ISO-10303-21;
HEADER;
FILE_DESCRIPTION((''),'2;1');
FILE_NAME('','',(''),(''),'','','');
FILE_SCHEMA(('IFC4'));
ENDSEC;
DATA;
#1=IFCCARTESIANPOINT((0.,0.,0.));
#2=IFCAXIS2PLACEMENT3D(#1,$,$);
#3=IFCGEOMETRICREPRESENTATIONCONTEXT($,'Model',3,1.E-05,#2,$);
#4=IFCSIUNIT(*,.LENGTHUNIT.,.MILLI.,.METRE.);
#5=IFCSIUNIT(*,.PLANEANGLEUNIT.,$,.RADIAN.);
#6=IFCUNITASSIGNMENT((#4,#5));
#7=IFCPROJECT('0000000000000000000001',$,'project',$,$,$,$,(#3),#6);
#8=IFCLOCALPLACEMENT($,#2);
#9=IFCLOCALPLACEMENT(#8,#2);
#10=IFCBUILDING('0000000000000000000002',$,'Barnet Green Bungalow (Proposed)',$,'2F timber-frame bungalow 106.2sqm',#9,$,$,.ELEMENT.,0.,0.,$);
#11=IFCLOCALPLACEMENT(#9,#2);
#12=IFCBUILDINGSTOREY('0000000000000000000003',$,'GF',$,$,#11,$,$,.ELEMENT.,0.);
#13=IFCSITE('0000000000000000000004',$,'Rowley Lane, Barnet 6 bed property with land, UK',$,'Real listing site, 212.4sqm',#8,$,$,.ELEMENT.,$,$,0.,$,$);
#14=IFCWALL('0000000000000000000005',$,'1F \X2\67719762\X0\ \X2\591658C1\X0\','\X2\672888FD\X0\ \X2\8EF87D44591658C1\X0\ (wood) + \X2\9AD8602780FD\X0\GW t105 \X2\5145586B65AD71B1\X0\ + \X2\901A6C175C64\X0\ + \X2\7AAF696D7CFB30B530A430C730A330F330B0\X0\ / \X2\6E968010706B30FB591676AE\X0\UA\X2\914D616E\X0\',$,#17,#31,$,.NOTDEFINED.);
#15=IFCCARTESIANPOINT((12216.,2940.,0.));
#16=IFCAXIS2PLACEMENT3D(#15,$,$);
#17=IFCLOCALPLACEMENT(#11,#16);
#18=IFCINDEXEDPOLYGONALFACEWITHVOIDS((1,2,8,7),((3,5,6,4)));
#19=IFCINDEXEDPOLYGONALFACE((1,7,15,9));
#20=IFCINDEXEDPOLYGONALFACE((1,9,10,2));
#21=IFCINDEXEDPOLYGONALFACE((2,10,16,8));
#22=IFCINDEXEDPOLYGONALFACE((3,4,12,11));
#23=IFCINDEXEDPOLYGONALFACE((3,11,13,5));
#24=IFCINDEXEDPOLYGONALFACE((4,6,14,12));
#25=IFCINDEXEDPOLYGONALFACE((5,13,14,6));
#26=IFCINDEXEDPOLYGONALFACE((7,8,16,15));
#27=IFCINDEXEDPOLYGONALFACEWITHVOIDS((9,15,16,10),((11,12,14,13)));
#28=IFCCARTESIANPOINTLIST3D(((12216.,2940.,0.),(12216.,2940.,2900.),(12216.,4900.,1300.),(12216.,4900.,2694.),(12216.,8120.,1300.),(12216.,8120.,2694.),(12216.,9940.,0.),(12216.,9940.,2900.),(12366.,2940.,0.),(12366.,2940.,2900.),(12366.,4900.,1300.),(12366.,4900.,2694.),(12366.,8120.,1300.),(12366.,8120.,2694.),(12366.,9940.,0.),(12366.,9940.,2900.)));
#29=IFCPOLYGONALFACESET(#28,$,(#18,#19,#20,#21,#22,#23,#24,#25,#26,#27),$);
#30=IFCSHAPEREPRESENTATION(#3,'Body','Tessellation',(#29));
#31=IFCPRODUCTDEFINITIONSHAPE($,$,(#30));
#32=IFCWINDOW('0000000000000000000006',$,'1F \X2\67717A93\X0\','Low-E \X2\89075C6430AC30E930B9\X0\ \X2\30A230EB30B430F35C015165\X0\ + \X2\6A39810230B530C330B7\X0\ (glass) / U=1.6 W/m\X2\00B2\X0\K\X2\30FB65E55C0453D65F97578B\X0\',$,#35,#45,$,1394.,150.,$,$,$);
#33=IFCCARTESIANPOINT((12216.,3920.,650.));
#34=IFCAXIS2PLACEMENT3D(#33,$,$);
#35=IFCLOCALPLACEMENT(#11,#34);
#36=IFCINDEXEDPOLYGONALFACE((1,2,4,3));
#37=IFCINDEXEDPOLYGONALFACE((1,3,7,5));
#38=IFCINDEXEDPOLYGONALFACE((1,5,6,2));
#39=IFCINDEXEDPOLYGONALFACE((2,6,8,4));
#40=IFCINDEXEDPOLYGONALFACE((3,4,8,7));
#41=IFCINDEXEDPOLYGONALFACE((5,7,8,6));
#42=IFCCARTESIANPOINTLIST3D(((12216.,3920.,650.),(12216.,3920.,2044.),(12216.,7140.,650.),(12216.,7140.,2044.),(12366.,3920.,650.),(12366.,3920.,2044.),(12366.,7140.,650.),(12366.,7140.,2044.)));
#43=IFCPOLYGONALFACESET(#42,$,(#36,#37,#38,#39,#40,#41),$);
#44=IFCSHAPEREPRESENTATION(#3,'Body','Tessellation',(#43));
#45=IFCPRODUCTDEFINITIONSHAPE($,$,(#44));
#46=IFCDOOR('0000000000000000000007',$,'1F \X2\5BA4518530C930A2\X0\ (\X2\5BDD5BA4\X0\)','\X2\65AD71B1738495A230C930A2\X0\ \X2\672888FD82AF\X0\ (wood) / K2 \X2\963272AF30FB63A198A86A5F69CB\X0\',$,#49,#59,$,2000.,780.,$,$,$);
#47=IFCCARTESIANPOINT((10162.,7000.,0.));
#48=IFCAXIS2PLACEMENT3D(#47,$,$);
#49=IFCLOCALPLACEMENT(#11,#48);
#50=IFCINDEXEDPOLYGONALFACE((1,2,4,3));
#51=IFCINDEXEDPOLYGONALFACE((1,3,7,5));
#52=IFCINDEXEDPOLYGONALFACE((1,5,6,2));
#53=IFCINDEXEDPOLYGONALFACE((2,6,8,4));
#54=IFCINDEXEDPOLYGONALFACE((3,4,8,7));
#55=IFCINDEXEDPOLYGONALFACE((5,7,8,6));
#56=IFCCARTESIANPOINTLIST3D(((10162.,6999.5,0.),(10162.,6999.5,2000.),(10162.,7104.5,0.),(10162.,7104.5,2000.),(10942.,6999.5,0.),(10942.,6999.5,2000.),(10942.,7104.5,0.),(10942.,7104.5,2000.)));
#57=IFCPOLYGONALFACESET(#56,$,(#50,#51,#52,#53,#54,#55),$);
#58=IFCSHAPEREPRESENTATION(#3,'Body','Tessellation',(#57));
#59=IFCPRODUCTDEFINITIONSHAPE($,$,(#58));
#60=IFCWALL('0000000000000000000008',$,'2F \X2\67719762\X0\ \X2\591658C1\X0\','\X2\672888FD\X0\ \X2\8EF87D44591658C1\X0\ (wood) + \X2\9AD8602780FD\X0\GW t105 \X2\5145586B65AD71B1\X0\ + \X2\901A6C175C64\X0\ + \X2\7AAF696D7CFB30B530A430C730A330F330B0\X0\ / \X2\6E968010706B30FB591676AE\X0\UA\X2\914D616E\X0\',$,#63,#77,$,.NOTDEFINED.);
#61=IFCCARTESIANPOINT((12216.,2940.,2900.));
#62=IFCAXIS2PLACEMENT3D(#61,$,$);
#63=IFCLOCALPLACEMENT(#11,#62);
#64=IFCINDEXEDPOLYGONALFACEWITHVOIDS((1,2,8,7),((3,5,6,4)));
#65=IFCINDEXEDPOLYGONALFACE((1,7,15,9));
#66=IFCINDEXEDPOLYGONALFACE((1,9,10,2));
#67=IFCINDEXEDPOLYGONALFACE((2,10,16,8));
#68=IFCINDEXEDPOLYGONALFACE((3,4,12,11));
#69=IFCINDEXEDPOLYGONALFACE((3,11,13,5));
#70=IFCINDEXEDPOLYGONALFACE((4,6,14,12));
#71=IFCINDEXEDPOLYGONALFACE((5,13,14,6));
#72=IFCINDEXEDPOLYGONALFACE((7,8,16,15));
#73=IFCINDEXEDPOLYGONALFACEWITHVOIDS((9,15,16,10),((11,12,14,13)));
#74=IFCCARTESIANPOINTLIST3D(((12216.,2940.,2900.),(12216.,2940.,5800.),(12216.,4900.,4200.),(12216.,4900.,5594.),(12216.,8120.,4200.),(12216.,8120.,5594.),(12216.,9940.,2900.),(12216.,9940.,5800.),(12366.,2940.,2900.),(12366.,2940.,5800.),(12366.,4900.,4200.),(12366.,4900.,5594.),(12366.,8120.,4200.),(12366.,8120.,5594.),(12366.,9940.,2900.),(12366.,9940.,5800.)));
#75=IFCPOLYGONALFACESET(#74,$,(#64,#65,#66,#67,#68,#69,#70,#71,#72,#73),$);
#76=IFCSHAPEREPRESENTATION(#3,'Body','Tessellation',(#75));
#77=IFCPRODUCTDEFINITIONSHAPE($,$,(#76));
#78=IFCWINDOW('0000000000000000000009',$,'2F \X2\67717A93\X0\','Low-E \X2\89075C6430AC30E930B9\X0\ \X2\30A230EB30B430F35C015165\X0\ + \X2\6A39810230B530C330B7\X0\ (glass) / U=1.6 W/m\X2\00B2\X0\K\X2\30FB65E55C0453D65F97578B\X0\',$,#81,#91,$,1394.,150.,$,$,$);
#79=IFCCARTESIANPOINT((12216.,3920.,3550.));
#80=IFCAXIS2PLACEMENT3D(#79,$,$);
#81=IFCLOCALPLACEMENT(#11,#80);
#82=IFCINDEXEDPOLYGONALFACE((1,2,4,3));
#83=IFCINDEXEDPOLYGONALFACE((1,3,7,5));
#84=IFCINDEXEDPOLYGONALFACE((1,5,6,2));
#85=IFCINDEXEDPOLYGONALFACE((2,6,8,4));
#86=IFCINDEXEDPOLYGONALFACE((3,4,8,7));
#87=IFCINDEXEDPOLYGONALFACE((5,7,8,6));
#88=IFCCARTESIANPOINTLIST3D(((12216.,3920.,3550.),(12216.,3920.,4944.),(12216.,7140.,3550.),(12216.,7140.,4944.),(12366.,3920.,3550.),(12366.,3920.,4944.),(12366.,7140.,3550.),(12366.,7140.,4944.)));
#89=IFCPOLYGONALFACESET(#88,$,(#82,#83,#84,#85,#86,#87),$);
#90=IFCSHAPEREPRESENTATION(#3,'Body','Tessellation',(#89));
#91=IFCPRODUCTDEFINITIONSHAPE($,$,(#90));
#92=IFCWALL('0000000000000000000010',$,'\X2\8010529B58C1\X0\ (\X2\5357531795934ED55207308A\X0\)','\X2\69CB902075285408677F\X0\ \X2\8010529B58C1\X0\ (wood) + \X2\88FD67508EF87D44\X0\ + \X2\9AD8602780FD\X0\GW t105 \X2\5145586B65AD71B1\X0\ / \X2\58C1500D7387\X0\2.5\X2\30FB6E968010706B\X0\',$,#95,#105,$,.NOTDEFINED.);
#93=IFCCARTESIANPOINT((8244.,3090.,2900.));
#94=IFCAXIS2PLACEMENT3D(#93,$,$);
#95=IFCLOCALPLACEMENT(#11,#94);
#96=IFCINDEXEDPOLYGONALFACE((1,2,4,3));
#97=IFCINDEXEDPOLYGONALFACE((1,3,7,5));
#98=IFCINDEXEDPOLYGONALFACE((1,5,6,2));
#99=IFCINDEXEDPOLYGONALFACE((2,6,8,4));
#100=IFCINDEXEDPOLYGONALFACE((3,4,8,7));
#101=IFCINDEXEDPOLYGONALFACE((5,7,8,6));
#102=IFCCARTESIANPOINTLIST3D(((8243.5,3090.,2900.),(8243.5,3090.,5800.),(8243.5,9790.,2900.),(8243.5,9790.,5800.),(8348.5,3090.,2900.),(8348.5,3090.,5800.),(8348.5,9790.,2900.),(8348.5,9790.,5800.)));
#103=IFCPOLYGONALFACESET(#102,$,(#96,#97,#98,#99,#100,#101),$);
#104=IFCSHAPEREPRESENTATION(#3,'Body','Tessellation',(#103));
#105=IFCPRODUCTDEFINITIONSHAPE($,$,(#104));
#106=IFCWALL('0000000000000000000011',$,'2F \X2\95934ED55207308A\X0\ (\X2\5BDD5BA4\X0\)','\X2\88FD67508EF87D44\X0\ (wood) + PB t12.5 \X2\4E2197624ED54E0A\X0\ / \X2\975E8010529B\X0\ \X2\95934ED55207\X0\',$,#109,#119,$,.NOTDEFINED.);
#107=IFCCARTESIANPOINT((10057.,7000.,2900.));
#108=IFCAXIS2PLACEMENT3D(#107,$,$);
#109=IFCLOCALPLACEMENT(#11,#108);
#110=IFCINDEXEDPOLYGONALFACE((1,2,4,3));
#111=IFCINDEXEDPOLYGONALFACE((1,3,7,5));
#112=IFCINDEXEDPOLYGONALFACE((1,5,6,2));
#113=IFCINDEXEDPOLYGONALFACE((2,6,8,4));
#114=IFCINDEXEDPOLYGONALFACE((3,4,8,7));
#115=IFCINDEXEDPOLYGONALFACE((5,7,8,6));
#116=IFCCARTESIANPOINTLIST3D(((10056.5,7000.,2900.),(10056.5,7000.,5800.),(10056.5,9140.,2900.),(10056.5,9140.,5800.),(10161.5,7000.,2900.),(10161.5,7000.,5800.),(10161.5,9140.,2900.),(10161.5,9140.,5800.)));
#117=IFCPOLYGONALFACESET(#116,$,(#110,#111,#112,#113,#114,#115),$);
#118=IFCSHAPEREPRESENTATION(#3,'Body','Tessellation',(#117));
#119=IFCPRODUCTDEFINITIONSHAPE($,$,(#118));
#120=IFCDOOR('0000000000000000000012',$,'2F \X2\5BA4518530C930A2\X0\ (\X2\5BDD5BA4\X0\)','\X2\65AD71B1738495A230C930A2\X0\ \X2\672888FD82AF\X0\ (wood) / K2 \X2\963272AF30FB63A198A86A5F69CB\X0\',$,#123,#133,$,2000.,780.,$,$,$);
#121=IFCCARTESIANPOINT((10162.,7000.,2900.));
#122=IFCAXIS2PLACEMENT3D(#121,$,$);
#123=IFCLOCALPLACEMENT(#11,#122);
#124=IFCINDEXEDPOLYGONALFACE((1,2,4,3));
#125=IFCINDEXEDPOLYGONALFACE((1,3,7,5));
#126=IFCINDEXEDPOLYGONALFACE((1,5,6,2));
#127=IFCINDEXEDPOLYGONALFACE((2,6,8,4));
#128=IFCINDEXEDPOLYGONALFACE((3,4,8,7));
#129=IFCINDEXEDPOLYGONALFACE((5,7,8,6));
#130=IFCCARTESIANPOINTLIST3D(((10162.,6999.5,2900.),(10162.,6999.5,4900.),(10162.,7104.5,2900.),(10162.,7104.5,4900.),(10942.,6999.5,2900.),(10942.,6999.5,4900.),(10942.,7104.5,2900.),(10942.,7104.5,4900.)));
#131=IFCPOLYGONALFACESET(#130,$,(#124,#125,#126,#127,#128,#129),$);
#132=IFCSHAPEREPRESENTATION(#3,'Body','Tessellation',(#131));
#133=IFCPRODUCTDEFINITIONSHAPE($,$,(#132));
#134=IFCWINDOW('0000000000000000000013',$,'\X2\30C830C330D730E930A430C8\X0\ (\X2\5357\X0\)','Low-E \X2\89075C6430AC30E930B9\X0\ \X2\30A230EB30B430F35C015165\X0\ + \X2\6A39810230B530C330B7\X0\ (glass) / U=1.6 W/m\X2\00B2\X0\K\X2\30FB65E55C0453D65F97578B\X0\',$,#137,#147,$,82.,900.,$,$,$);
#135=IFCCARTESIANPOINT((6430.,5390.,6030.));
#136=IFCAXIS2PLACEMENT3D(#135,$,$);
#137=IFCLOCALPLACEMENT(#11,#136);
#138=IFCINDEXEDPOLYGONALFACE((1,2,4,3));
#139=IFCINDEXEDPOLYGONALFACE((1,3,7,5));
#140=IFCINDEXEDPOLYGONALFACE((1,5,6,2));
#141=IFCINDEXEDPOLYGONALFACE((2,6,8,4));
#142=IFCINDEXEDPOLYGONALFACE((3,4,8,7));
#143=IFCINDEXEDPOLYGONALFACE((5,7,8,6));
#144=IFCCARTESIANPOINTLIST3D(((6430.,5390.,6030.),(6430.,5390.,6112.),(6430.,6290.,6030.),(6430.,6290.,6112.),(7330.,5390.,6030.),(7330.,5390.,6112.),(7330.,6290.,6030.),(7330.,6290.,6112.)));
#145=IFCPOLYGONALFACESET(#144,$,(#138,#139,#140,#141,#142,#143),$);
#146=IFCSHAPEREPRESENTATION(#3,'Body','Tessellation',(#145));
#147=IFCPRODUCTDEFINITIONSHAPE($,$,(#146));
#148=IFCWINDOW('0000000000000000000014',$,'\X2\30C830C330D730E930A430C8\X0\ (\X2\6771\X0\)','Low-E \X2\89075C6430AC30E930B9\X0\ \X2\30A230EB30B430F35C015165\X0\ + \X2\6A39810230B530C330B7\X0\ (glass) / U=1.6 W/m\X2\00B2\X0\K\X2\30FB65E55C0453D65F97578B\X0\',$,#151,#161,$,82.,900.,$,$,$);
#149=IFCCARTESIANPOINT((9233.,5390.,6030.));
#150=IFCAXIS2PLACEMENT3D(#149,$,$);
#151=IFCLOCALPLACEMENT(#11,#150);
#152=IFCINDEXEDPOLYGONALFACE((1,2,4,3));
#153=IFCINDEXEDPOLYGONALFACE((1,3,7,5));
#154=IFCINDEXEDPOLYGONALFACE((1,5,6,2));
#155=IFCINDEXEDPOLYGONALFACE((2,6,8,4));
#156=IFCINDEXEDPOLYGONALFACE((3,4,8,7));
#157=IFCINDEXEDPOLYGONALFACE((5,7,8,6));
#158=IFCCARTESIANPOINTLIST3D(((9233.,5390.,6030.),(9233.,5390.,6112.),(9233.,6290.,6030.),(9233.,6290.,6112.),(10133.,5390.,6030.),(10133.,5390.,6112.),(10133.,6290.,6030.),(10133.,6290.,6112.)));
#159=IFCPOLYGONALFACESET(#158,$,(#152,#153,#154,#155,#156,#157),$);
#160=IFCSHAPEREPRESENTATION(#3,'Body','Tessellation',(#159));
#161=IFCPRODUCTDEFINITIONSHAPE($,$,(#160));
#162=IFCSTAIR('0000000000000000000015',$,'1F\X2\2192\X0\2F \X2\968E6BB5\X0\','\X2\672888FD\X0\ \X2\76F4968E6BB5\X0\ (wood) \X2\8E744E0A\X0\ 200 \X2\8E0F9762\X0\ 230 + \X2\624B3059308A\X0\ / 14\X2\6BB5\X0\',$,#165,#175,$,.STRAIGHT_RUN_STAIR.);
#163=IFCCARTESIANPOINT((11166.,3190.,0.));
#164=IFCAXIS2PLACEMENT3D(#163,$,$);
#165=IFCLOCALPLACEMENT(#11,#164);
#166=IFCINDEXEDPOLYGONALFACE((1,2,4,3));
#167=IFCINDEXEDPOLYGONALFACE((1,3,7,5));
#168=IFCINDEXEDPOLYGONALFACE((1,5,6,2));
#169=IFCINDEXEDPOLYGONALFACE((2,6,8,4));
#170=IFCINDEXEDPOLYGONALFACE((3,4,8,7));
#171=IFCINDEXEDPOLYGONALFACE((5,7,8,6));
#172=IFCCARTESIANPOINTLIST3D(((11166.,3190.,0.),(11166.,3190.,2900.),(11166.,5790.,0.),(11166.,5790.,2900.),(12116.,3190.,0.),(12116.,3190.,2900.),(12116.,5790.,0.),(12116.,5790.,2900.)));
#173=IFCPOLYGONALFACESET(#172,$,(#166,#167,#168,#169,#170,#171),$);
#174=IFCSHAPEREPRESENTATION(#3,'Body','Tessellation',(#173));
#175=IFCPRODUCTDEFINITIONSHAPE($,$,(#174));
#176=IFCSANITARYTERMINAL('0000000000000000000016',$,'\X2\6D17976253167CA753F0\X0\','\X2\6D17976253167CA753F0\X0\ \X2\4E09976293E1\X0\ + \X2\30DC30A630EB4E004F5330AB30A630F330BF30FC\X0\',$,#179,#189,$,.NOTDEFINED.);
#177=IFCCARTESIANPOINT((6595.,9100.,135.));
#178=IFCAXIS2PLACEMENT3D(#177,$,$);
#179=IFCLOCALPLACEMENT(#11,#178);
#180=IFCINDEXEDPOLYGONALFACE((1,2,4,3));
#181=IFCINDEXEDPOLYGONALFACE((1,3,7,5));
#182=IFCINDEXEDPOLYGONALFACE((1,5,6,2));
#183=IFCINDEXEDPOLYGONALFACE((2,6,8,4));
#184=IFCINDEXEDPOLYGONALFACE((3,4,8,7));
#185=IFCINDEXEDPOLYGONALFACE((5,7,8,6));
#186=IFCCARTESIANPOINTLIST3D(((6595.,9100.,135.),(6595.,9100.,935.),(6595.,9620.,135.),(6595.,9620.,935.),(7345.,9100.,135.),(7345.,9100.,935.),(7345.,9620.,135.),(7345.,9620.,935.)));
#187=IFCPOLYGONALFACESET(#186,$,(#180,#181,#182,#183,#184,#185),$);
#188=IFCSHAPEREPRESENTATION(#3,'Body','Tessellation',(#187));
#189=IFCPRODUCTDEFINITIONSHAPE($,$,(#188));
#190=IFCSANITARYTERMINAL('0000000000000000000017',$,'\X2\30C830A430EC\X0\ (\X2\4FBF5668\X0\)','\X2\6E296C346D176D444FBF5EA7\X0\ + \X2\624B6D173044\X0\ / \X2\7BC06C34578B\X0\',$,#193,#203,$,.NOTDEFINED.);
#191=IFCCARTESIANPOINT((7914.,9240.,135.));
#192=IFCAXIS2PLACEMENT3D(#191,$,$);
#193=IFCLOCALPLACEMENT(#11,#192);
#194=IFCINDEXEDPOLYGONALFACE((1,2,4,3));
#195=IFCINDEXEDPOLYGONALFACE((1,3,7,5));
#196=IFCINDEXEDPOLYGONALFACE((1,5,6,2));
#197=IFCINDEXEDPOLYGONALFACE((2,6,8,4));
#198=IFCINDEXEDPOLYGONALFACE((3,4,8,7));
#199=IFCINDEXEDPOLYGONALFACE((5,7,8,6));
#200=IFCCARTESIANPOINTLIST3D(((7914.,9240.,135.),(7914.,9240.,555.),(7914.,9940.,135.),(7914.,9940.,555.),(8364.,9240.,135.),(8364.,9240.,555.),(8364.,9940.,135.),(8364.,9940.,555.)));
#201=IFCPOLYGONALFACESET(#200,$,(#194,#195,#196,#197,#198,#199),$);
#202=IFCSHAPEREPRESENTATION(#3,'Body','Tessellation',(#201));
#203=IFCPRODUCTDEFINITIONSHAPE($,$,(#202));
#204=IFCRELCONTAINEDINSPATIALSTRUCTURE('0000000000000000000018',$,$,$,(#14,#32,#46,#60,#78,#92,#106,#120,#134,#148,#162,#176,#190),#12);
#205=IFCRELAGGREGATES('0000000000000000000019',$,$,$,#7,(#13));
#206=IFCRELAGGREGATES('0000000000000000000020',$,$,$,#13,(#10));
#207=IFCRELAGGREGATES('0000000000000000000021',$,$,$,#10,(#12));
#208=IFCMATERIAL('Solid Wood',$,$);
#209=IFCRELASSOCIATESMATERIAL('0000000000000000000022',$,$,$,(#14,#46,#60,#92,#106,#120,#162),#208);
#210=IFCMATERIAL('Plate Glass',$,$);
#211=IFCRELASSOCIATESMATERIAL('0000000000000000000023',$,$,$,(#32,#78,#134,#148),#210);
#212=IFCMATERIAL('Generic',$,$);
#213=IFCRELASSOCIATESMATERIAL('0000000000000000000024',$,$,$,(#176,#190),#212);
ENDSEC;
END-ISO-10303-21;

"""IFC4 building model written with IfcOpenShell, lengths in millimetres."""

from ifc_helpers import new_model, si_unit, frame, frame_2d, origin, place, context, project, spatial, rectangle, extrude, material, element, fill, save


model = new_model("IFC4")

# Units and contexts
model_context = context("Model", 3, precision=1e-05, world=origin())
ifc_project = project(units=[si_unit("LENGTHUNIT", "METRE", prefix="MILLI"), si_unit("PLANEANGLEUNIT", "RADIAN")], contexts=[model_context])

# Site, building, storey
site_placement = place(None, origin())
site = spatial("IfcSite", under=ifc_project, at=site_placement, Name="Rowley Lane, Barnet 6 bed property with land, UK", ObjectType="Real listing site, 212.4sqm", CompositionType="ELEMENT", RefElevation=0.0)
building_placement = place(site_placement, origin())
building = spatial("IfcBuilding", under=site, at=building_placement, Name="Barnet Green Bungalow (Proposed)", ObjectType="2F timber-frame bungalow 106.2sqm", CompositionType="ELEMENT", ElevationOfRefHeight=0.0, ElevationOfTerrain=0.0)
storey_placement = place(building_placement, origin())
storey = spatial("IfcBuildingStorey", under=building, at=storey_placement, Name="GF", CompositionType="ELEMENT", Elevation=0.0)

# Wall, opening, window
ifc_material_1 = material(Name="Solid Wood")
wall_1_placement = place(storey_placement, frame((12216.0, 2940.0, 0.0)))
wall_1 = element("IfcWall", 1, at=wall_1_placement, inside=storey, material=ifc_material_1, Name="1F 東面 外壁", Description="木製 軸組外壁 (wood) + 高性能GW t105 充填断熱 + 通気層 + 窯業系サイディング / 準耐火・外皮UA配慮", PredefinedType="NOTDEFINED", context=model_context, shape_type="SweptSolid", body=[
    extrude(rectangle(XDim=150.0, YDim=7000.0, at=frame_2d((75.0, 3500.0))), frame((12216.0, 2940.0, 0.0)), (0.0, 0.0, 1.0), 2900.0),
])
opening_1_placement = place(storey_placement, frame((12216.0, 3920.0, 650.0)))
opening_1 = element("IfcOpeningElement", 2, at=opening_1_placement, cuts=wall_1, PredefinedType="NOTDEFINED", context=model_context, shape_type="SweptSolid", body=[
    extrude(rectangle(XDim=150.0, YDim=3220.0, at=frame_2d((75.0, 1610.0))), frame((12216.0, 3920.0, 650.0)), (0.0, 0.0, 1.0), 1394.0),
])
ifc_material_2 = material(Name="Plate Glass")
window_1_placement = place(storey_placement, frame((12216.0, 3920.0, 650.0)))
window_1 = element("IfcWindow", 3, at=window_1_placement, inside=storey, material=ifc_material_2, Name="1F 東窓", Description="Low-E 複層ガラス アルゴン封入 + 樹脂サッシ (glass) / U=1.6 W/m²K・日射取得型", OverallHeight=1394.0, OverallWidth=150.0, context=model_context, shape_type="SweptSolid", body=[
    extrude(rectangle(XDim=150.0, YDim=3220.0, at=frame_2d((75.0, 1610.0))), frame((12216.0, 3920.0, 650.0)), (0.0, 0.0, 1.0), 1394.0),
])
fill(opening_1, window_1)

# Door
door_1_placement = place(storey_placement, frame((10162.0, 7000.0, 0.0)))
element("IfcDoor", 4, at=door_1_placement, inside=storey, material=ifc_material_1, Name="1F 室内ドア (寝室)", Description="断熱玄関ドア 木製芯 (wood) / K2 防犯・採風機構", OverallHeight=2000.0, OverallWidth=780.0, context=model_context, shape_type="SweptSolid", body=[
    extrude(rectangle(XDim=780.0, YDim=105.0, at=frame_2d((390.0, 52.0))), frame((10162.0, 7000.0, 0.0)), (0.0, 0.0, 1.0), 2000.0),
])

# Wall, opening, window
wall_2_placement = place(storey_placement, frame((12216.0, 2940.0, 2900.0)))
wall_2 = element("IfcWall", 5, at=wall_2_placement, inside=storey, material=ifc_material_1, Name="2F 東面 外壁", Description="木製 軸組外壁 (wood) + 高性能GW t105 充填断熱 + 通気層 + 窯業系サイディング / 準耐火・外皮UA配慮", PredefinedType="NOTDEFINED", context=model_context, shape_type="SweptSolid", body=[
    extrude(rectangle(XDim=150.0, YDim=7000.0, at=frame_2d((75.0, 3500.0))), frame((12216.0, 2940.0, 2900.0)), (0.0, 0.0, 1.0), 2900.0),
])
opening_2_placement = place(storey_placement, frame((12216.0, 3920.0, 3550.0)))
opening_2 = element("IfcOpeningElement", 6, at=opening_2_placement, cuts=wall_2, PredefinedType="NOTDEFINED", context=model_context, shape_type="SweptSolid", body=[
    extrude(rectangle(XDim=150.0, YDim=3220.0, at=frame_2d((75.0, 1610.0))), frame((12216.0, 3920.0, 3550.0)), (0.0, 0.0, 1.0), 1394.0),
])
window_2_placement = place(storey_placement, frame((12216.0, 3920.0, 3550.0)))
window_2 = element("IfcWindow", 7, at=window_2_placement, inside=storey, material=ifc_material_2, Name="2F 東窓", Description="Low-E 複層ガラス アルゴン封入 + 樹脂サッシ (glass) / U=1.6 W/m²K・日射取得型", OverallHeight=1394.0, OverallWidth=150.0, context=model_context, shape_type="SweptSolid", body=[
    extrude(rectangle(XDim=150.0, YDim=3220.0, at=frame_2d((75.0, 1610.0))), frame((12216.0, 3920.0, 3550.0)), (0.0, 0.0, 1.0), 1394.0),
])
fill(opening_2, window_2)

# Walls
wall_3_placement = place(storey_placement, frame((8244.0, 3090.0, 2900.0)))
element("IfcWall", 8, at=wall_3_placement, inside=storey, material=ifc_material_1, Name="耐力壁 (南北間仕切り)", Description="構造用合板 耐力壁 (wood) + 製材軸組 + 高性能GW t105 充填断熱 / 壁倍率2.5・準耐火", PredefinedType="NOTDEFINED", context=model_context, shape_type="SweptSolid", body=[
    extrude(rectangle(XDim=105.0, YDim=6700.0, at=frame_2d((52.0, 3350.0))), frame((8244.0, 3090.0, 2900.0)), (0.0, 0.0, 1.0), 2900.0),
])
wall_4_placement = place(storey_placement, frame((10057.0, 7000.0, 2900.0)))
element("IfcWall", 9, at=wall_4_placement, inside=storey, material=ifc_material_1, Name="2F 間仕切り (寝室)", Description="製材軸組 (wood) + PB t12.5 両面仕上 / 非耐力 間仕切", PredefinedType="NOTDEFINED", context=model_context, shape_type="SweptSolid", body=[
    extrude(rectangle(XDim=105.0, YDim=2140.0, at=frame_2d((52.0, 1070.0))), frame((10057.0, 7000.0, 2900.0)), (0.0, 0.0, 1.0), 2900.0),
])

# Door
door_2_placement = place(storey_placement, frame((10162.0, 7000.0, 2900.0)))
element("IfcDoor", 10, at=door_2_placement, inside=storey, material=ifc_material_1, Name="2F 室内ドア (寝室)", Description="断熱玄関ドア 木製芯 (wood) / K2 防犯・採風機構", OverallHeight=2000.0, OverallWidth=780.0, context=model_context, shape_type="SweptSolid", body=[
    extrude(rectangle(XDim=780.0, YDim=105.0, at=frame_2d((390.0, 52.0))), frame((10162.0, 7000.0, 2900.0)), (0.0, 0.0, 1.0), 2000.0),
])

# Windows
window_3_placement = place(storey_placement, frame((6430.0, 5390.0, 6030.0)))
element("IfcWindow", 11, at=window_3_placement, inside=storey, material=ifc_material_2, Name="トップライト (南)", Description="Low-E 複層ガラス アルゴン封入 + 樹脂サッシ (glass) / U=1.6 W/m²K・日射取得型", OverallHeight=82.0, OverallWidth=900.0, context=model_context, shape_type="SweptSolid", body=[
    extrude(rectangle(XDim=900.0, YDim=900.0, at=frame_2d((450.0, 450.0))), frame((6430.0, 5390.0, 6030.0)), (0.0, 0.0, 1.0), 82.0),
])
window_4_placement = place(storey_placement, frame((9233.0, 5390.0, 6030.0)))
element("IfcWindow", 12, at=window_4_placement, inside=storey, material=ifc_material_2, Name="トップライト (東)", Description="Low-E 複層ガラス アルゴン封入 + 樹脂サッシ (glass) / U=1.6 W/m²K・日射取得型", OverallHeight=82.0, OverallWidth=900.0, context=model_context, shape_type="SweptSolid", body=[
    extrude(rectangle(XDim=900.0, YDim=900.0, at=frame_2d((450.0, 450.0))), frame((9233.0, 5390.0, 6030.0)), (0.0, 0.0, 1.0), 82.0),
])

# Stair
stair_placement = place(storey_placement, frame((11166.0, 3190.0, 0.0)))
element("IfcStair", 13, at=stair_placement, inside=storey, material=ifc_material_1, Name="1F→2F 階段", Description="木製 直階段 (wood) 蹴上 200 踏面 230 + 手すり / 14段", PredefinedType="STRAIGHT_RUN_STAIR", context=model_context, shape_type="SweptSolid", body=[
    extrude(rectangle(XDim=950.0, YDim=2600.0, at=frame_2d((475.0, 1300.0))), frame((11166.0, 3190.0, 0.0)), (0.0, 0.0, 1.0), 2900.0),
])

# Sanitary terminals
ifc_material_3 = material(Name="Generic")
sanitary_terminal_1_placement = place(storey_placement, frame((6595.0, 9100.0, 135.0)))
element("IfcSanitaryTerminal", 14, at=sanitary_terminal_1_placement, inside=storey, material=ifc_material_3, Name="洗面化粧台", Description="洗面化粧台 三面鏡 + ボウル一体カウンター", PredefinedType="NOTDEFINED", context=model_context, shape_type="SweptSolid", body=[
    extrude(rectangle(XDim=750.0, YDim=520.0, at=frame_2d((375.0, 260.0))), frame((6595.0, 9100.0, 135.0)), (0.0, 0.0, 1.0), 800.0),
])
sanitary_terminal_2_placement = place(storey_placement, frame((7914.0, 9240.0, 135.0)))
element("IfcSanitaryTerminal", 15, at=sanitary_terminal_2_placement, inside=storey, material=ifc_material_3, Name="トイレ (便器)", Description="温水洗浄便座 + 手洗い / 節水型", PredefinedType="NOTDEFINED", context=model_context, shape_type="SweptSolid", body=[
    extrude(rectangle(XDim=450.0, YDim=700.0, at=frame_2d((225.0, 350.0))), frame((7914.0, 9240.0, 135.0)), (0.0, 0.0, 1.0), 420.0),
])

save(model, "model.ifc")
